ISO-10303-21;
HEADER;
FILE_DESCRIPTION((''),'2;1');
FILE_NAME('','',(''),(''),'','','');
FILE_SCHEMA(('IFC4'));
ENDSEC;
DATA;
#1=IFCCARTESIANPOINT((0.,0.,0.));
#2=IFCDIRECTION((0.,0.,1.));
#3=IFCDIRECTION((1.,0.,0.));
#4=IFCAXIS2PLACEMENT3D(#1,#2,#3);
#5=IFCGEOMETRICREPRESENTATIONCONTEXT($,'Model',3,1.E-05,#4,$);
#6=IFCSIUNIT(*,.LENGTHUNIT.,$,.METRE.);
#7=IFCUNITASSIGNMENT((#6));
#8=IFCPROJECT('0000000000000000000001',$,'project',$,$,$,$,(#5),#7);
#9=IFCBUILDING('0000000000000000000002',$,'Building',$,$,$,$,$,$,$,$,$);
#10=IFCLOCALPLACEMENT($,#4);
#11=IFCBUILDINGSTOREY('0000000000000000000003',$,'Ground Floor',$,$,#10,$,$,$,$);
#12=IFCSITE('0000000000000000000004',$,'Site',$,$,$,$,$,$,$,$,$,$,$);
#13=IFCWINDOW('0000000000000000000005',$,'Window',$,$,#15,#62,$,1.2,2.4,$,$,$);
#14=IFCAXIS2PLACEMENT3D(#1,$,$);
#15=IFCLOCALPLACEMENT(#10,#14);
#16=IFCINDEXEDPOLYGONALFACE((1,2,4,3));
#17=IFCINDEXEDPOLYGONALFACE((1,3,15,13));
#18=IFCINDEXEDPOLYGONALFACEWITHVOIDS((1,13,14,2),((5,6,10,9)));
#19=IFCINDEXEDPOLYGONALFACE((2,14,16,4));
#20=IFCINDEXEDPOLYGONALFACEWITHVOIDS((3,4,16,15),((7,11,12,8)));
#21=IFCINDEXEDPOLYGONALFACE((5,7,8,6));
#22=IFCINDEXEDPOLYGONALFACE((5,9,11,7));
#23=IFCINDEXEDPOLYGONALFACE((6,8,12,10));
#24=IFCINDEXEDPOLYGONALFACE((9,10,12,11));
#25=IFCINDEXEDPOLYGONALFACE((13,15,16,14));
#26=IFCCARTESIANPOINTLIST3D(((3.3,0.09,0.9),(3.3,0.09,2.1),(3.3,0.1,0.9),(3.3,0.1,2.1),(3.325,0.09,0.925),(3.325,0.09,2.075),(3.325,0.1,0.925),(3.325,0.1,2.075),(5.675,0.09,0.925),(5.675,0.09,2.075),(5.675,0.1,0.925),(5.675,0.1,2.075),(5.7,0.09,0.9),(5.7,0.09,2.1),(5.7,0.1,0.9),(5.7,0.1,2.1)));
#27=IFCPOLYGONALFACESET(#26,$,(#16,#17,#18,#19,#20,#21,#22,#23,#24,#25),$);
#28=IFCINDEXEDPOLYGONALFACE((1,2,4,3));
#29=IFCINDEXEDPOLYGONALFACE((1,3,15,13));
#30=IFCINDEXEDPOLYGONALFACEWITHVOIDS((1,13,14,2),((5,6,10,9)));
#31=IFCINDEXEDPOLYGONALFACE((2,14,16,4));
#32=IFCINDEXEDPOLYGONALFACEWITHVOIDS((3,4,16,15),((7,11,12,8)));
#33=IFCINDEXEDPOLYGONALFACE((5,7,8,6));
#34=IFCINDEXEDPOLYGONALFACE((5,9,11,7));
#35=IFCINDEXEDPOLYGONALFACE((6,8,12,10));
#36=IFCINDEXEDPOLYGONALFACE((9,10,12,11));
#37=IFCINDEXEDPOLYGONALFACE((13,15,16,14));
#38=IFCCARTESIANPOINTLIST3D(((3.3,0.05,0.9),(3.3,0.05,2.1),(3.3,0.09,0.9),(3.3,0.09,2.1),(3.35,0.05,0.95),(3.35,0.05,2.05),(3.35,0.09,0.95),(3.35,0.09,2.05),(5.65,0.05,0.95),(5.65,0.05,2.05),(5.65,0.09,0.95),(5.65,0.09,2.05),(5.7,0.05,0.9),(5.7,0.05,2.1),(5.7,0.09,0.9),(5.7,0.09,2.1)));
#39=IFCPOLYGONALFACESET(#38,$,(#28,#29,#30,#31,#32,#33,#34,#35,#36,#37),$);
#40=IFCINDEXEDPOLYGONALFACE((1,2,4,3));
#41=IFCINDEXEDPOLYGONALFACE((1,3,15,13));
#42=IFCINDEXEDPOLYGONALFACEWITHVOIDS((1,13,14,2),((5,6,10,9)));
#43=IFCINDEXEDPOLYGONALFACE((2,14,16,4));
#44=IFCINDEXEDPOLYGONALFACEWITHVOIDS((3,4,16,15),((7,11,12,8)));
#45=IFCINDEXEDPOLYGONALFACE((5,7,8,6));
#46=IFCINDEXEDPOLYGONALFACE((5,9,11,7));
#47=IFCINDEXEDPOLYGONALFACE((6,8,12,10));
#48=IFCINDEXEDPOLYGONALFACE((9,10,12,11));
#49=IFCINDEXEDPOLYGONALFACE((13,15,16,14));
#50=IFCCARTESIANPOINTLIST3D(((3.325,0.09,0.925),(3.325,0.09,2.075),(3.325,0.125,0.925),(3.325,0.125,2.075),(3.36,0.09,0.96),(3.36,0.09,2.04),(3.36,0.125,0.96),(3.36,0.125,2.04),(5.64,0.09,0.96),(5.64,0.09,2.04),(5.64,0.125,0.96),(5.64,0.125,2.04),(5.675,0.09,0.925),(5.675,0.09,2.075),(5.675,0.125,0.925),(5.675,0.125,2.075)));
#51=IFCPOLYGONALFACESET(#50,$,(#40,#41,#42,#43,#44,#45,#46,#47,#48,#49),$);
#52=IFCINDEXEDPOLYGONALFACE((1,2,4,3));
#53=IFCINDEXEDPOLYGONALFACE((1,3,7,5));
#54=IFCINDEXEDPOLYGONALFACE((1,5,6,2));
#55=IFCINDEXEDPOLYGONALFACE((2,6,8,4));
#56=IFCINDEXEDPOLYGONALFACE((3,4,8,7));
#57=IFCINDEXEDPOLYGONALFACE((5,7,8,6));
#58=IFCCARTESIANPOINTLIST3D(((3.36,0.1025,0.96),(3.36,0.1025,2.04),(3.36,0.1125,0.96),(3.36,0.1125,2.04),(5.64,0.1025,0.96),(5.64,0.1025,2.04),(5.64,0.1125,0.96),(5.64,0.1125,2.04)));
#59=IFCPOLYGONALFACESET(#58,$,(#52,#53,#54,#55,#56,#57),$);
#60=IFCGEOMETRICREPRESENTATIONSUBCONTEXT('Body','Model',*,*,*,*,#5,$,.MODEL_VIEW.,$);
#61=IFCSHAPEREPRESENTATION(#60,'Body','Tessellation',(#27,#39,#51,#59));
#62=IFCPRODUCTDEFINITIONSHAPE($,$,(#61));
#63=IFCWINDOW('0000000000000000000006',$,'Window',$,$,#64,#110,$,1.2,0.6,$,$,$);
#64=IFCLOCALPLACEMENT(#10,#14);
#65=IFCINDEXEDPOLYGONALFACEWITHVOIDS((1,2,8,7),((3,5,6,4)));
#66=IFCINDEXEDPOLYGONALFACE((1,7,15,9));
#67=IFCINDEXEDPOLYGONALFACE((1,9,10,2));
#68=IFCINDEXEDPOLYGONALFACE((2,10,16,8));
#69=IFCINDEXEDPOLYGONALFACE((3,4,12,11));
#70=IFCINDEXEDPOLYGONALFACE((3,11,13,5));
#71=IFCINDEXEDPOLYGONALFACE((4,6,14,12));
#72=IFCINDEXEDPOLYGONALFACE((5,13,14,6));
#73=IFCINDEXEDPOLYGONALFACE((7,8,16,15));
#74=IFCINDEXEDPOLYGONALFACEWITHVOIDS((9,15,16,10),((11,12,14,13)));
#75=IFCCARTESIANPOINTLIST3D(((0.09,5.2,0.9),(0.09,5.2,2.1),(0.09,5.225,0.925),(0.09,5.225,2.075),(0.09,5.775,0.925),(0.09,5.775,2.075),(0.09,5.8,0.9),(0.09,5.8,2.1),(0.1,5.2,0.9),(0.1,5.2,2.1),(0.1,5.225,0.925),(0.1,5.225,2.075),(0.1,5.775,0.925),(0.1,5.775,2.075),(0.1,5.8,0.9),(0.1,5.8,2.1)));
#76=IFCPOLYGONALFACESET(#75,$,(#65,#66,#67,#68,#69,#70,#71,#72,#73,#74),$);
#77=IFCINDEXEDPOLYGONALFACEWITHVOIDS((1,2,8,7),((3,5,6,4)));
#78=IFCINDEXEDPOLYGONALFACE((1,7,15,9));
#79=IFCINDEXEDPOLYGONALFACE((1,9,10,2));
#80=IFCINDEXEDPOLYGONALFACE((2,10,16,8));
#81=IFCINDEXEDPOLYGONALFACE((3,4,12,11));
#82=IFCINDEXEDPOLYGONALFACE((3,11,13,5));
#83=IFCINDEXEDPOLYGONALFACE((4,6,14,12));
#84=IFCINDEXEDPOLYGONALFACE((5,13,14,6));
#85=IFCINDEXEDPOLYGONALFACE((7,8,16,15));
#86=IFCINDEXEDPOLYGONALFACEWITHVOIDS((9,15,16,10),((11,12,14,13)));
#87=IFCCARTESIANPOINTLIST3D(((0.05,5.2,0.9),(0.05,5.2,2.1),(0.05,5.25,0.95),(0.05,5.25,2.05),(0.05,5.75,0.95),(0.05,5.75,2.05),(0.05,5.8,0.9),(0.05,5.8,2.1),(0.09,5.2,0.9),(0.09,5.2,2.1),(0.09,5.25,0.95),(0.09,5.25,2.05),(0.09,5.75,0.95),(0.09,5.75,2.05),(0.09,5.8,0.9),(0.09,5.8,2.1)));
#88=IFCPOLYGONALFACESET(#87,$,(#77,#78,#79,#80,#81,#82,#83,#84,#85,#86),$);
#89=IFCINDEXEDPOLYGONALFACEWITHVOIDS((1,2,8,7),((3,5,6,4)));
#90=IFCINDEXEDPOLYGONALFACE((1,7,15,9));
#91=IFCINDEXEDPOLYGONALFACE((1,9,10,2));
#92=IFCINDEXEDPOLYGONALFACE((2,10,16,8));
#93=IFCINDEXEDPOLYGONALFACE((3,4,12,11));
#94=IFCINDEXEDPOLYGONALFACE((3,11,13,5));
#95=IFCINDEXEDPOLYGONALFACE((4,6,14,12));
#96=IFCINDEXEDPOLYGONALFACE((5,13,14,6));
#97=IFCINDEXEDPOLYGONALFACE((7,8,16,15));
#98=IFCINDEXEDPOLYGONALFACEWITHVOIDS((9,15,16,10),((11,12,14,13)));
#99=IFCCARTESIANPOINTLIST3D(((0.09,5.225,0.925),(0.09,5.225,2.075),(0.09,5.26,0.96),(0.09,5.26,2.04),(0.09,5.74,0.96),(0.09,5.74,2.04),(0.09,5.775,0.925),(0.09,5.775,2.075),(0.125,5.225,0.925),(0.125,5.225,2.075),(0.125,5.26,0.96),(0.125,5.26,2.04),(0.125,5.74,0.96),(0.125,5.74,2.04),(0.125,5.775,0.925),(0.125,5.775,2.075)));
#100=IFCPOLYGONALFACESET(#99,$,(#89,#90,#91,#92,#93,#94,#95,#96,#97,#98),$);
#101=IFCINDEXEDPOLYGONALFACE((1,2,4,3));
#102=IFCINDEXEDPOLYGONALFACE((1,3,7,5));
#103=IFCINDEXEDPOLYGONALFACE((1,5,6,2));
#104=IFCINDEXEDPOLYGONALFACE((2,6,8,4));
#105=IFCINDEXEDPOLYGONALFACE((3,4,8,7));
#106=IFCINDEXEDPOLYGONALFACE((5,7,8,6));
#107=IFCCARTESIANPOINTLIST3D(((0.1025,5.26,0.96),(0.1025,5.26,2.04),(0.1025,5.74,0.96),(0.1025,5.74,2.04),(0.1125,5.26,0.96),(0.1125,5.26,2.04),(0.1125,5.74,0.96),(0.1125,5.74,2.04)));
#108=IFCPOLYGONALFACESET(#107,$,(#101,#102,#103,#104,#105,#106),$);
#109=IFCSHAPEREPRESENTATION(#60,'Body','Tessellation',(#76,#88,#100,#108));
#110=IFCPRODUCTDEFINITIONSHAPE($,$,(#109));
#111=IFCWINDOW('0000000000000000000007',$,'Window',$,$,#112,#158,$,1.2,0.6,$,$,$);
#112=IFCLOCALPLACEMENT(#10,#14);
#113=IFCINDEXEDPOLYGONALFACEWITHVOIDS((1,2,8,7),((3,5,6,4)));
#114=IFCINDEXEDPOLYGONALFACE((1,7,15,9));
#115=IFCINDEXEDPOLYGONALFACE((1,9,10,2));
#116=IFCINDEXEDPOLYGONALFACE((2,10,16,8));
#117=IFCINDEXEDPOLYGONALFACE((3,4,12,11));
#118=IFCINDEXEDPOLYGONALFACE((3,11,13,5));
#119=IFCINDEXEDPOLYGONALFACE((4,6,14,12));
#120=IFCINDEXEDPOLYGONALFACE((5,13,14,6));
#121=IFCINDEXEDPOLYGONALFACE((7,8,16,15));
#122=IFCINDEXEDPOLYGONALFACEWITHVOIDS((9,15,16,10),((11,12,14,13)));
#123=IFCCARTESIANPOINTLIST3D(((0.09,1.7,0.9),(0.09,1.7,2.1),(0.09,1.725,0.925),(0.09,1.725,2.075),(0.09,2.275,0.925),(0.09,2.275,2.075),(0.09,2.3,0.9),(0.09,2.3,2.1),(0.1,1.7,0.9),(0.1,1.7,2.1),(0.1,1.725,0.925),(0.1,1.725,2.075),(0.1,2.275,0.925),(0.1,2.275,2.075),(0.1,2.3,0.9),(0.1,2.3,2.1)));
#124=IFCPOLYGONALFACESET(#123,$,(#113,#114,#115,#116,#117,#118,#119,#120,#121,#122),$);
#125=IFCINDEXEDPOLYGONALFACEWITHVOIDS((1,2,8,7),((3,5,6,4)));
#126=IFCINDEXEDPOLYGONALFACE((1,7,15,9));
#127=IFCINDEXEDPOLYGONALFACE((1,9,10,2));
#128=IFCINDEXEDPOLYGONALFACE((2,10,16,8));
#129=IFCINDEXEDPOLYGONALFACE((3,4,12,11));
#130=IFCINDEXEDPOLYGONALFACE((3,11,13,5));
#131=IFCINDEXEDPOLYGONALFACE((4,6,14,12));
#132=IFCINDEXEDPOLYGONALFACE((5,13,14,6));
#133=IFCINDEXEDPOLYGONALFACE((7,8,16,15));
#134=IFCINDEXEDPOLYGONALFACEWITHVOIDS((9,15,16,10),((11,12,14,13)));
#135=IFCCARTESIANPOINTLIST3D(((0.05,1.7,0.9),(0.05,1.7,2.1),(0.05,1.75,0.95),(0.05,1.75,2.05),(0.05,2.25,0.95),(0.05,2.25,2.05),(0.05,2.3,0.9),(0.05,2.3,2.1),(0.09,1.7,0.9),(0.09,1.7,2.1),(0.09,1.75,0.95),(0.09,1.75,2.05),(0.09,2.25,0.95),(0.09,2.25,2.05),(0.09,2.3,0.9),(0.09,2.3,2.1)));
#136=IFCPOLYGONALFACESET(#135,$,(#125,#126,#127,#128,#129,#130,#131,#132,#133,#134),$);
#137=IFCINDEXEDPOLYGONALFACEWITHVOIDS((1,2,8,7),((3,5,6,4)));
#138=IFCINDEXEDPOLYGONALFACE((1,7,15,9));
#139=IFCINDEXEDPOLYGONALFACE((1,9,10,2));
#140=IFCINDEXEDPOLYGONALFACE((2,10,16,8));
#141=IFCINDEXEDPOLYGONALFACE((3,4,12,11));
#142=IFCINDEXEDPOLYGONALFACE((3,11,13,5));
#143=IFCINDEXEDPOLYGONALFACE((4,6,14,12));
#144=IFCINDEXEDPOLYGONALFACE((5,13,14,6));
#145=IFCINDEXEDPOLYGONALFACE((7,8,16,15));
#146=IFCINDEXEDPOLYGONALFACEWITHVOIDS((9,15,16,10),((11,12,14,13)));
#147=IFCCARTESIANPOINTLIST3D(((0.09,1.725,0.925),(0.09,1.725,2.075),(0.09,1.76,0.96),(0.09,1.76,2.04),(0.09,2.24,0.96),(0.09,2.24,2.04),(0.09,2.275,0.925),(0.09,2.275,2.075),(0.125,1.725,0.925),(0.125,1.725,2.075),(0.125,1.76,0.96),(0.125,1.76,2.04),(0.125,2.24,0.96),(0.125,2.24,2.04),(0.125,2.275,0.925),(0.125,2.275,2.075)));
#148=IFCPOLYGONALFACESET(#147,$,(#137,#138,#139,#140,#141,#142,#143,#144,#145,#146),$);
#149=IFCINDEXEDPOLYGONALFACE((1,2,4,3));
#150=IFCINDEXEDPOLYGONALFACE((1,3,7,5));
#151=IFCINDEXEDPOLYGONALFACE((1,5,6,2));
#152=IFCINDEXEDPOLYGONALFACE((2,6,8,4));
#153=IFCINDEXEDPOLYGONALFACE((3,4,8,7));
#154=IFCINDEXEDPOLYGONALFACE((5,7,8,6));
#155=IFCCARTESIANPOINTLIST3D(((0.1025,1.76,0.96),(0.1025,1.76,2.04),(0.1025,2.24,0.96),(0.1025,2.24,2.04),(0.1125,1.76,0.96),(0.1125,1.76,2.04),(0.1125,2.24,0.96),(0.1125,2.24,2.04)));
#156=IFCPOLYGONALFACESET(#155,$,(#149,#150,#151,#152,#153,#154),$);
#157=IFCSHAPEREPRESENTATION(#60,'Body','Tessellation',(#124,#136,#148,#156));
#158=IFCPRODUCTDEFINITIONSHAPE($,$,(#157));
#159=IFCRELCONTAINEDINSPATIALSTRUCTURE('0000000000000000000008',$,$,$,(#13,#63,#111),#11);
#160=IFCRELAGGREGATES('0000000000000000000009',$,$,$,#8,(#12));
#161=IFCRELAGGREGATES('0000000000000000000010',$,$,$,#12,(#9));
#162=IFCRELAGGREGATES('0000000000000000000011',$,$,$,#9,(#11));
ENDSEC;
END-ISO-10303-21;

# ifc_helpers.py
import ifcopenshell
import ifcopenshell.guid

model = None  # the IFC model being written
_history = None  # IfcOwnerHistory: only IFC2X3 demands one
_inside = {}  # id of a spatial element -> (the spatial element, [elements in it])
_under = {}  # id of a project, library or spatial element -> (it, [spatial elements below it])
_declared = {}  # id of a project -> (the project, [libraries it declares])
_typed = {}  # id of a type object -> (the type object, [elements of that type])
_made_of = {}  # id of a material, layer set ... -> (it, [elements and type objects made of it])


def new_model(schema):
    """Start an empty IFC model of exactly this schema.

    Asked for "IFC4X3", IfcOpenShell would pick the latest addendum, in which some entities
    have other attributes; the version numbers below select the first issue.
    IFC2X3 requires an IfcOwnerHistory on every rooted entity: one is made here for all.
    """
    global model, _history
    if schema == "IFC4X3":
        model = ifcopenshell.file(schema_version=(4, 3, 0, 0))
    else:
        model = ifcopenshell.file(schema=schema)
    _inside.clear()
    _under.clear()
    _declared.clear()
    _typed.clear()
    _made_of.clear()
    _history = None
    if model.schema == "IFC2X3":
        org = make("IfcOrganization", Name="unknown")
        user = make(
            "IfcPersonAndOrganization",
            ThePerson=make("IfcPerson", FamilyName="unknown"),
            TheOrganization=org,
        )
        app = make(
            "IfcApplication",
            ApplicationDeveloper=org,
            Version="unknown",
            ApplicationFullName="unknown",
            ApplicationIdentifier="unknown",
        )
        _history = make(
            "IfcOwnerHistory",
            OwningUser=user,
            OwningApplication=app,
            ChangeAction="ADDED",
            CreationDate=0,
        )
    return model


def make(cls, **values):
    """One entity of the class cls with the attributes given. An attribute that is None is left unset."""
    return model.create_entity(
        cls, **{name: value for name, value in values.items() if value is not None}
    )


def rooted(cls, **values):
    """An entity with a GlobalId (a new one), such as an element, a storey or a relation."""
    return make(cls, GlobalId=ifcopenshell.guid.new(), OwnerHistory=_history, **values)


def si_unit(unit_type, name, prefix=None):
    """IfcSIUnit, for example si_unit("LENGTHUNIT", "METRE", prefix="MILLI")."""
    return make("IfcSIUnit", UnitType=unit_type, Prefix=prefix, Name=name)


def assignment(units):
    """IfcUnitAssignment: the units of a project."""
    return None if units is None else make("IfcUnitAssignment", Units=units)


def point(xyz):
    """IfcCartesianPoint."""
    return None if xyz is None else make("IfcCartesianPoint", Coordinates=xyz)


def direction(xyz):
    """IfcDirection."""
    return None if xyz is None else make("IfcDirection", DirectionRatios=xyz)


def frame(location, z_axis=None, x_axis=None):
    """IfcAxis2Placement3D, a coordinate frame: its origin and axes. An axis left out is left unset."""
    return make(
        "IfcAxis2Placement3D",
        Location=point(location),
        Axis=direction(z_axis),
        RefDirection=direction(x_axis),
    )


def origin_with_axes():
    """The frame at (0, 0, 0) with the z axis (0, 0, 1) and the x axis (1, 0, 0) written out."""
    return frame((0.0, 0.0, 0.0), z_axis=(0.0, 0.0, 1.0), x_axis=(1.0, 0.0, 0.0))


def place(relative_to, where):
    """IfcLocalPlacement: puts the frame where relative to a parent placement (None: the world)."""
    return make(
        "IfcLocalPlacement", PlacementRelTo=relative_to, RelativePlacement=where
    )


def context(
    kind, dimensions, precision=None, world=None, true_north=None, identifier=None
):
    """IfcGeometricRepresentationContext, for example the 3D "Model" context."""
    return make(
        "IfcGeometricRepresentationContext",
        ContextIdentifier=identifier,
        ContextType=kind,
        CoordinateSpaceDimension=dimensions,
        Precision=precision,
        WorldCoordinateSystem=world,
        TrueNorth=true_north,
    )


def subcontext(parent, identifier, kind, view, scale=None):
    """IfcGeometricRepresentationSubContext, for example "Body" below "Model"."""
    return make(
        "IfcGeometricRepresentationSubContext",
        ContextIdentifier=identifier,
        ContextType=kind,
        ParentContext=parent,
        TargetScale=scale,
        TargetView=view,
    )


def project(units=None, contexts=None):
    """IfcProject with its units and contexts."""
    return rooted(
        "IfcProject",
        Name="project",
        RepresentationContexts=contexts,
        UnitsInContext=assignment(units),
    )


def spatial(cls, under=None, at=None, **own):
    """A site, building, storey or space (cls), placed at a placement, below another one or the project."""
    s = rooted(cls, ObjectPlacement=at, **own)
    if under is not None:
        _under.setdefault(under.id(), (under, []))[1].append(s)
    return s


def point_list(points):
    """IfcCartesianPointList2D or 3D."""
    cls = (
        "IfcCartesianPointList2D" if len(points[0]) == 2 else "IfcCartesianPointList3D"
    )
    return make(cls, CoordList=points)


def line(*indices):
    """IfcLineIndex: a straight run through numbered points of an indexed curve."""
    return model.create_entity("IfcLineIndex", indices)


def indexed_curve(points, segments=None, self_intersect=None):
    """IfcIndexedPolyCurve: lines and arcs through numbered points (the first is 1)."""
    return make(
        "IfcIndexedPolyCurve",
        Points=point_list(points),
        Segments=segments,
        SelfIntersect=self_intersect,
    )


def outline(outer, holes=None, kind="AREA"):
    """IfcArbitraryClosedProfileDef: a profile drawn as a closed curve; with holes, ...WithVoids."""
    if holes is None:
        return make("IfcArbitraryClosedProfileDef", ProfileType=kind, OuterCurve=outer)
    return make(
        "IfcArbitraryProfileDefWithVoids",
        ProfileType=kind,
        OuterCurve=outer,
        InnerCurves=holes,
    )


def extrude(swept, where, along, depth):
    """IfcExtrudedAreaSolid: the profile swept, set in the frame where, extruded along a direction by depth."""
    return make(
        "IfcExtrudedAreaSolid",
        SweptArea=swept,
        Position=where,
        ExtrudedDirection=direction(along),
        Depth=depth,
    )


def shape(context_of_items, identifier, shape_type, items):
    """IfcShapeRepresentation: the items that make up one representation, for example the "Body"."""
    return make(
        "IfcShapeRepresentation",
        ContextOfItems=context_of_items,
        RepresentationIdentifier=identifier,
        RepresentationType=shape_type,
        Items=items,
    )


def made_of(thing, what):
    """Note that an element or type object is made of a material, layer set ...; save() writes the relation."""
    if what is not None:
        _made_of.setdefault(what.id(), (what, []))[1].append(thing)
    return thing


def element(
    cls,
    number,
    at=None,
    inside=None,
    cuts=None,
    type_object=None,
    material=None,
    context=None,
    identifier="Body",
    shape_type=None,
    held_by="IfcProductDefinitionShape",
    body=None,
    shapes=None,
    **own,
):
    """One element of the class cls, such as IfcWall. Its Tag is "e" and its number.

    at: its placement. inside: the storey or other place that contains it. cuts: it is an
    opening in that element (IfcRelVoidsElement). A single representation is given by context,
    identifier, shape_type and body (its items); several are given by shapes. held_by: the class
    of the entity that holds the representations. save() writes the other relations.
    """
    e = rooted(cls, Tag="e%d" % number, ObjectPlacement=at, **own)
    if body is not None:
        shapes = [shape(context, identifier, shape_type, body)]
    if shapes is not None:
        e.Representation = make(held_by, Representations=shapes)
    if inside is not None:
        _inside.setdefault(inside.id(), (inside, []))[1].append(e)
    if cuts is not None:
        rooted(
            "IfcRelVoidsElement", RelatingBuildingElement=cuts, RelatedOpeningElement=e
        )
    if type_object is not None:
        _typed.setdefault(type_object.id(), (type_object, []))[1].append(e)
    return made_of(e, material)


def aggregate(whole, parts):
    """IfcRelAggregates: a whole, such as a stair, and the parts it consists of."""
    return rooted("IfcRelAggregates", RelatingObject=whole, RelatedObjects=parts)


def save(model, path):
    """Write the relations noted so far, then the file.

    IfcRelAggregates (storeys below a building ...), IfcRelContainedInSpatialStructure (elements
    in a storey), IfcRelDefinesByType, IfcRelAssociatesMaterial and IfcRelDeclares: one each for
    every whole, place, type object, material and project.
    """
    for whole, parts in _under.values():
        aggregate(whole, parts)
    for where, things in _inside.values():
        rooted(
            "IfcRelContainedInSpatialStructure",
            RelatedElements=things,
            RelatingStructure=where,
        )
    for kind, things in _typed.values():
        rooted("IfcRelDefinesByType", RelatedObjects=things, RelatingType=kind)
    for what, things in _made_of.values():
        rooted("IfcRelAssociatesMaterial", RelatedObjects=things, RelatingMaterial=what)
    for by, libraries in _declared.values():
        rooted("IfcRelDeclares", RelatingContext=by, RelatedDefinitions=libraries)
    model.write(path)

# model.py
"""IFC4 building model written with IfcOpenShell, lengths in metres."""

from ifc_helpers import new_model, si_unit, frame, origin_with_axes, place, context, subcontext, project, spatial, line, indexed_curve, outline, extrude, element, save


model = new_model("IFC4")

# Units and contexts
model_context = context("Model", 3, precision=1e-05, world=origin_with_axes())
body_context = subcontext(model_context, "Body", "Model", "MODEL_VIEW")
ifc_project = project(units=[si_unit("LENGTHUNIT", "METRE")], contexts=[model_context])

# Site, building, storey
site = spatial("IfcSite", under=ifc_project, Name="Site")
building = spatial("IfcBuilding", under=site, Name="Building")
storey_placement = place(None, origin_with_axes())
storey = spatial("IfcBuildingStorey", under=building, at=storey_placement, Name="Ground Floor")

# Windows
window_placement = place(storey_placement, frame((3.3, 0.0, 0.9), z_axis=(0.0, 0.0, 1.0), x_axis=(1.0, 0.0, 0.0)))
element("IfcWindow", 1, at=window_placement, inside=storey, Name="Window", OverallHeight=1.2, OverallWidth=2.4, context=body_context, shape_type="SweptSolid", body=[
    extrude(outline(indexed_curve([(0.0, 0.0), (2.4, 0.0), (2.4, 1.2), (0.0, 1.2)], segments=[line(1, 2, 3, 4, 1)]), holes=[indexed_curve([(0.025, 0.025), (2.375, 0.025), (2.375, 1.175), (0.025, 1.175)], segments=[line(1, 2, 3, 4, 1)])]), frame((0.0, 0.09, 0.0), z_axis=(0.0, -1.0, 0.0), x_axis=(1.0, 0.0, 0.0)), (0.0, 0.0, -1.0), 0.01),
    extrude(outline(indexed_curve([(0.0, 0.0), (2.4, 0.0), (2.4, 1.2), (0.0, 1.2)], segments=[line(1, 2, 3, 4, 1)]), holes=[indexed_curve([(0.05, 0.05), (2.35, 0.05), (2.35, 1.15), (0.05, 1.15)], segments=[line(1, 2, 3, 4, 1)])]), frame((0.0, 0.05, 0.0), z_axis=(0.0, -1.0, 0.0), x_axis=(1.0, 0.0, 0.0)), (0.0, 0.0, -1.0), 0.04),
    extrude(outline(indexed_curve([(0.0, 0.0), (2.35, 0.0), (2.35, 1.15), (0.0, 1.15)], segments=[line(1, 2, 3, 4, 1)]), holes=[indexed_curve([(0.035, 0.035), (2.315, 0.035), (2.315, 1.115), (0.035, 1.115)], segments=[line(1, 2, 3, 4, 1)])]), frame((0.025, 0.09, 0.025), z_axis=(0.0, -1.0, 0.0), x_axis=(1.0, 0.0, 0.0)), (0.0, 0.0, -1.0), 0.035),
    extrude(outline(indexed_curve([(0.035, 0.035), (2.315, 0.035), (2.315, 1.115), (0.035, 1.115)], segments=[line(1, 2, 3, 4, 1)])), frame((0.025, 0.1025, 0.025), z_axis=(0.0, -1.0, 0.0), x_axis=(1.0, 0.0, 0.0)), (0.0, 0.0, -1.0), 0.01),
])
for number, where, z_axis, x_axis, name in (
    (2, (0.0, 5.8, 0.9), (0.0, 0.0, 1.0), (0.0, -1.0, 0.0), "Window"),
    (3, (0.0, 2.3, 0.9), (0.0, 0.0, 1.0), (0.0, -1.0, 0.0), "Window"),
):
    element("IfcWindow", number, at=place(storey_placement, frame(where, z_axis=z_axis, x_axis=x_axis)), inside=storey, Name=name, OverallHeight=1.2, OverallWidth=0.6, context=body_context, shape_type="SweptSolid", body=[
        extrude(outline(indexed_curve([(0.0, 0.0), (0.6, 0.0), (0.6, 1.2), (0.0, 1.2)], segments=[line(1, 2, 3, 4, 1)]), holes=[indexed_curve([(0.025, 0.025), (0.575, 0.025), (0.575, 1.175), (0.025, 1.175)], segments=[line(1, 2, 3, 4, 1)])]), frame((0.0, 0.09, 0.0), z_axis=(0.0, -1.0, 0.0), x_axis=(1.0, 0.0, 0.0)), (0.0, 0.0, -1.0), 0.01),
        extrude(outline(indexed_curve([(0.0, 0.0), (0.6, 0.0), (0.6, 1.2), (0.0, 1.2)], segments=[line(1, 2, 3, 4, 1)]), holes=[indexed_curve([(0.05, 0.05), (0.55, 0.05), (0.55, 1.15), (0.05, 1.15)], segments=[line(1, 2, 3, 4, 1)])]), frame((0.0, 0.05, 0.0), z_axis=(0.0, -1.0, 0.0), x_axis=(1.0, 0.0, 0.0)), (0.0, 0.0, -1.0), 0.04),
        extrude(outline(indexed_curve([(0.0, 0.0), (0.55, 0.0), (0.55, 1.15), (0.0, 1.15)], segments=[line(1, 2, 3, 4, 1)]), holes=[indexed_curve([(0.035, 0.035), (0.515, 0.035), (0.515, 1.115), (0.035, 1.115)], segments=[line(1, 2, 3, 4, 1)])]), frame((0.025, 0.09, 0.025), z_axis=(0.0, -1.0, 0.0), x_axis=(1.0, 0.0, 0.0)), (0.0, 0.0, -1.0), 0.035),
        extrude(outline(indexed_curve([(0.035, 0.035), (0.515, 0.035), (0.515, 1.115), (0.035, 1.115)], segments=[line(1, 2, 3, 4, 1)])), frame((0.025, 0.1025, 0.025), z_axis=(0.0, -1.0, 0.0), x_axis=(1.0, 0.0, 0.0)), (0.0, 0.0, -1.0), 0.01),
    ])

save(model, "model.ifc")
